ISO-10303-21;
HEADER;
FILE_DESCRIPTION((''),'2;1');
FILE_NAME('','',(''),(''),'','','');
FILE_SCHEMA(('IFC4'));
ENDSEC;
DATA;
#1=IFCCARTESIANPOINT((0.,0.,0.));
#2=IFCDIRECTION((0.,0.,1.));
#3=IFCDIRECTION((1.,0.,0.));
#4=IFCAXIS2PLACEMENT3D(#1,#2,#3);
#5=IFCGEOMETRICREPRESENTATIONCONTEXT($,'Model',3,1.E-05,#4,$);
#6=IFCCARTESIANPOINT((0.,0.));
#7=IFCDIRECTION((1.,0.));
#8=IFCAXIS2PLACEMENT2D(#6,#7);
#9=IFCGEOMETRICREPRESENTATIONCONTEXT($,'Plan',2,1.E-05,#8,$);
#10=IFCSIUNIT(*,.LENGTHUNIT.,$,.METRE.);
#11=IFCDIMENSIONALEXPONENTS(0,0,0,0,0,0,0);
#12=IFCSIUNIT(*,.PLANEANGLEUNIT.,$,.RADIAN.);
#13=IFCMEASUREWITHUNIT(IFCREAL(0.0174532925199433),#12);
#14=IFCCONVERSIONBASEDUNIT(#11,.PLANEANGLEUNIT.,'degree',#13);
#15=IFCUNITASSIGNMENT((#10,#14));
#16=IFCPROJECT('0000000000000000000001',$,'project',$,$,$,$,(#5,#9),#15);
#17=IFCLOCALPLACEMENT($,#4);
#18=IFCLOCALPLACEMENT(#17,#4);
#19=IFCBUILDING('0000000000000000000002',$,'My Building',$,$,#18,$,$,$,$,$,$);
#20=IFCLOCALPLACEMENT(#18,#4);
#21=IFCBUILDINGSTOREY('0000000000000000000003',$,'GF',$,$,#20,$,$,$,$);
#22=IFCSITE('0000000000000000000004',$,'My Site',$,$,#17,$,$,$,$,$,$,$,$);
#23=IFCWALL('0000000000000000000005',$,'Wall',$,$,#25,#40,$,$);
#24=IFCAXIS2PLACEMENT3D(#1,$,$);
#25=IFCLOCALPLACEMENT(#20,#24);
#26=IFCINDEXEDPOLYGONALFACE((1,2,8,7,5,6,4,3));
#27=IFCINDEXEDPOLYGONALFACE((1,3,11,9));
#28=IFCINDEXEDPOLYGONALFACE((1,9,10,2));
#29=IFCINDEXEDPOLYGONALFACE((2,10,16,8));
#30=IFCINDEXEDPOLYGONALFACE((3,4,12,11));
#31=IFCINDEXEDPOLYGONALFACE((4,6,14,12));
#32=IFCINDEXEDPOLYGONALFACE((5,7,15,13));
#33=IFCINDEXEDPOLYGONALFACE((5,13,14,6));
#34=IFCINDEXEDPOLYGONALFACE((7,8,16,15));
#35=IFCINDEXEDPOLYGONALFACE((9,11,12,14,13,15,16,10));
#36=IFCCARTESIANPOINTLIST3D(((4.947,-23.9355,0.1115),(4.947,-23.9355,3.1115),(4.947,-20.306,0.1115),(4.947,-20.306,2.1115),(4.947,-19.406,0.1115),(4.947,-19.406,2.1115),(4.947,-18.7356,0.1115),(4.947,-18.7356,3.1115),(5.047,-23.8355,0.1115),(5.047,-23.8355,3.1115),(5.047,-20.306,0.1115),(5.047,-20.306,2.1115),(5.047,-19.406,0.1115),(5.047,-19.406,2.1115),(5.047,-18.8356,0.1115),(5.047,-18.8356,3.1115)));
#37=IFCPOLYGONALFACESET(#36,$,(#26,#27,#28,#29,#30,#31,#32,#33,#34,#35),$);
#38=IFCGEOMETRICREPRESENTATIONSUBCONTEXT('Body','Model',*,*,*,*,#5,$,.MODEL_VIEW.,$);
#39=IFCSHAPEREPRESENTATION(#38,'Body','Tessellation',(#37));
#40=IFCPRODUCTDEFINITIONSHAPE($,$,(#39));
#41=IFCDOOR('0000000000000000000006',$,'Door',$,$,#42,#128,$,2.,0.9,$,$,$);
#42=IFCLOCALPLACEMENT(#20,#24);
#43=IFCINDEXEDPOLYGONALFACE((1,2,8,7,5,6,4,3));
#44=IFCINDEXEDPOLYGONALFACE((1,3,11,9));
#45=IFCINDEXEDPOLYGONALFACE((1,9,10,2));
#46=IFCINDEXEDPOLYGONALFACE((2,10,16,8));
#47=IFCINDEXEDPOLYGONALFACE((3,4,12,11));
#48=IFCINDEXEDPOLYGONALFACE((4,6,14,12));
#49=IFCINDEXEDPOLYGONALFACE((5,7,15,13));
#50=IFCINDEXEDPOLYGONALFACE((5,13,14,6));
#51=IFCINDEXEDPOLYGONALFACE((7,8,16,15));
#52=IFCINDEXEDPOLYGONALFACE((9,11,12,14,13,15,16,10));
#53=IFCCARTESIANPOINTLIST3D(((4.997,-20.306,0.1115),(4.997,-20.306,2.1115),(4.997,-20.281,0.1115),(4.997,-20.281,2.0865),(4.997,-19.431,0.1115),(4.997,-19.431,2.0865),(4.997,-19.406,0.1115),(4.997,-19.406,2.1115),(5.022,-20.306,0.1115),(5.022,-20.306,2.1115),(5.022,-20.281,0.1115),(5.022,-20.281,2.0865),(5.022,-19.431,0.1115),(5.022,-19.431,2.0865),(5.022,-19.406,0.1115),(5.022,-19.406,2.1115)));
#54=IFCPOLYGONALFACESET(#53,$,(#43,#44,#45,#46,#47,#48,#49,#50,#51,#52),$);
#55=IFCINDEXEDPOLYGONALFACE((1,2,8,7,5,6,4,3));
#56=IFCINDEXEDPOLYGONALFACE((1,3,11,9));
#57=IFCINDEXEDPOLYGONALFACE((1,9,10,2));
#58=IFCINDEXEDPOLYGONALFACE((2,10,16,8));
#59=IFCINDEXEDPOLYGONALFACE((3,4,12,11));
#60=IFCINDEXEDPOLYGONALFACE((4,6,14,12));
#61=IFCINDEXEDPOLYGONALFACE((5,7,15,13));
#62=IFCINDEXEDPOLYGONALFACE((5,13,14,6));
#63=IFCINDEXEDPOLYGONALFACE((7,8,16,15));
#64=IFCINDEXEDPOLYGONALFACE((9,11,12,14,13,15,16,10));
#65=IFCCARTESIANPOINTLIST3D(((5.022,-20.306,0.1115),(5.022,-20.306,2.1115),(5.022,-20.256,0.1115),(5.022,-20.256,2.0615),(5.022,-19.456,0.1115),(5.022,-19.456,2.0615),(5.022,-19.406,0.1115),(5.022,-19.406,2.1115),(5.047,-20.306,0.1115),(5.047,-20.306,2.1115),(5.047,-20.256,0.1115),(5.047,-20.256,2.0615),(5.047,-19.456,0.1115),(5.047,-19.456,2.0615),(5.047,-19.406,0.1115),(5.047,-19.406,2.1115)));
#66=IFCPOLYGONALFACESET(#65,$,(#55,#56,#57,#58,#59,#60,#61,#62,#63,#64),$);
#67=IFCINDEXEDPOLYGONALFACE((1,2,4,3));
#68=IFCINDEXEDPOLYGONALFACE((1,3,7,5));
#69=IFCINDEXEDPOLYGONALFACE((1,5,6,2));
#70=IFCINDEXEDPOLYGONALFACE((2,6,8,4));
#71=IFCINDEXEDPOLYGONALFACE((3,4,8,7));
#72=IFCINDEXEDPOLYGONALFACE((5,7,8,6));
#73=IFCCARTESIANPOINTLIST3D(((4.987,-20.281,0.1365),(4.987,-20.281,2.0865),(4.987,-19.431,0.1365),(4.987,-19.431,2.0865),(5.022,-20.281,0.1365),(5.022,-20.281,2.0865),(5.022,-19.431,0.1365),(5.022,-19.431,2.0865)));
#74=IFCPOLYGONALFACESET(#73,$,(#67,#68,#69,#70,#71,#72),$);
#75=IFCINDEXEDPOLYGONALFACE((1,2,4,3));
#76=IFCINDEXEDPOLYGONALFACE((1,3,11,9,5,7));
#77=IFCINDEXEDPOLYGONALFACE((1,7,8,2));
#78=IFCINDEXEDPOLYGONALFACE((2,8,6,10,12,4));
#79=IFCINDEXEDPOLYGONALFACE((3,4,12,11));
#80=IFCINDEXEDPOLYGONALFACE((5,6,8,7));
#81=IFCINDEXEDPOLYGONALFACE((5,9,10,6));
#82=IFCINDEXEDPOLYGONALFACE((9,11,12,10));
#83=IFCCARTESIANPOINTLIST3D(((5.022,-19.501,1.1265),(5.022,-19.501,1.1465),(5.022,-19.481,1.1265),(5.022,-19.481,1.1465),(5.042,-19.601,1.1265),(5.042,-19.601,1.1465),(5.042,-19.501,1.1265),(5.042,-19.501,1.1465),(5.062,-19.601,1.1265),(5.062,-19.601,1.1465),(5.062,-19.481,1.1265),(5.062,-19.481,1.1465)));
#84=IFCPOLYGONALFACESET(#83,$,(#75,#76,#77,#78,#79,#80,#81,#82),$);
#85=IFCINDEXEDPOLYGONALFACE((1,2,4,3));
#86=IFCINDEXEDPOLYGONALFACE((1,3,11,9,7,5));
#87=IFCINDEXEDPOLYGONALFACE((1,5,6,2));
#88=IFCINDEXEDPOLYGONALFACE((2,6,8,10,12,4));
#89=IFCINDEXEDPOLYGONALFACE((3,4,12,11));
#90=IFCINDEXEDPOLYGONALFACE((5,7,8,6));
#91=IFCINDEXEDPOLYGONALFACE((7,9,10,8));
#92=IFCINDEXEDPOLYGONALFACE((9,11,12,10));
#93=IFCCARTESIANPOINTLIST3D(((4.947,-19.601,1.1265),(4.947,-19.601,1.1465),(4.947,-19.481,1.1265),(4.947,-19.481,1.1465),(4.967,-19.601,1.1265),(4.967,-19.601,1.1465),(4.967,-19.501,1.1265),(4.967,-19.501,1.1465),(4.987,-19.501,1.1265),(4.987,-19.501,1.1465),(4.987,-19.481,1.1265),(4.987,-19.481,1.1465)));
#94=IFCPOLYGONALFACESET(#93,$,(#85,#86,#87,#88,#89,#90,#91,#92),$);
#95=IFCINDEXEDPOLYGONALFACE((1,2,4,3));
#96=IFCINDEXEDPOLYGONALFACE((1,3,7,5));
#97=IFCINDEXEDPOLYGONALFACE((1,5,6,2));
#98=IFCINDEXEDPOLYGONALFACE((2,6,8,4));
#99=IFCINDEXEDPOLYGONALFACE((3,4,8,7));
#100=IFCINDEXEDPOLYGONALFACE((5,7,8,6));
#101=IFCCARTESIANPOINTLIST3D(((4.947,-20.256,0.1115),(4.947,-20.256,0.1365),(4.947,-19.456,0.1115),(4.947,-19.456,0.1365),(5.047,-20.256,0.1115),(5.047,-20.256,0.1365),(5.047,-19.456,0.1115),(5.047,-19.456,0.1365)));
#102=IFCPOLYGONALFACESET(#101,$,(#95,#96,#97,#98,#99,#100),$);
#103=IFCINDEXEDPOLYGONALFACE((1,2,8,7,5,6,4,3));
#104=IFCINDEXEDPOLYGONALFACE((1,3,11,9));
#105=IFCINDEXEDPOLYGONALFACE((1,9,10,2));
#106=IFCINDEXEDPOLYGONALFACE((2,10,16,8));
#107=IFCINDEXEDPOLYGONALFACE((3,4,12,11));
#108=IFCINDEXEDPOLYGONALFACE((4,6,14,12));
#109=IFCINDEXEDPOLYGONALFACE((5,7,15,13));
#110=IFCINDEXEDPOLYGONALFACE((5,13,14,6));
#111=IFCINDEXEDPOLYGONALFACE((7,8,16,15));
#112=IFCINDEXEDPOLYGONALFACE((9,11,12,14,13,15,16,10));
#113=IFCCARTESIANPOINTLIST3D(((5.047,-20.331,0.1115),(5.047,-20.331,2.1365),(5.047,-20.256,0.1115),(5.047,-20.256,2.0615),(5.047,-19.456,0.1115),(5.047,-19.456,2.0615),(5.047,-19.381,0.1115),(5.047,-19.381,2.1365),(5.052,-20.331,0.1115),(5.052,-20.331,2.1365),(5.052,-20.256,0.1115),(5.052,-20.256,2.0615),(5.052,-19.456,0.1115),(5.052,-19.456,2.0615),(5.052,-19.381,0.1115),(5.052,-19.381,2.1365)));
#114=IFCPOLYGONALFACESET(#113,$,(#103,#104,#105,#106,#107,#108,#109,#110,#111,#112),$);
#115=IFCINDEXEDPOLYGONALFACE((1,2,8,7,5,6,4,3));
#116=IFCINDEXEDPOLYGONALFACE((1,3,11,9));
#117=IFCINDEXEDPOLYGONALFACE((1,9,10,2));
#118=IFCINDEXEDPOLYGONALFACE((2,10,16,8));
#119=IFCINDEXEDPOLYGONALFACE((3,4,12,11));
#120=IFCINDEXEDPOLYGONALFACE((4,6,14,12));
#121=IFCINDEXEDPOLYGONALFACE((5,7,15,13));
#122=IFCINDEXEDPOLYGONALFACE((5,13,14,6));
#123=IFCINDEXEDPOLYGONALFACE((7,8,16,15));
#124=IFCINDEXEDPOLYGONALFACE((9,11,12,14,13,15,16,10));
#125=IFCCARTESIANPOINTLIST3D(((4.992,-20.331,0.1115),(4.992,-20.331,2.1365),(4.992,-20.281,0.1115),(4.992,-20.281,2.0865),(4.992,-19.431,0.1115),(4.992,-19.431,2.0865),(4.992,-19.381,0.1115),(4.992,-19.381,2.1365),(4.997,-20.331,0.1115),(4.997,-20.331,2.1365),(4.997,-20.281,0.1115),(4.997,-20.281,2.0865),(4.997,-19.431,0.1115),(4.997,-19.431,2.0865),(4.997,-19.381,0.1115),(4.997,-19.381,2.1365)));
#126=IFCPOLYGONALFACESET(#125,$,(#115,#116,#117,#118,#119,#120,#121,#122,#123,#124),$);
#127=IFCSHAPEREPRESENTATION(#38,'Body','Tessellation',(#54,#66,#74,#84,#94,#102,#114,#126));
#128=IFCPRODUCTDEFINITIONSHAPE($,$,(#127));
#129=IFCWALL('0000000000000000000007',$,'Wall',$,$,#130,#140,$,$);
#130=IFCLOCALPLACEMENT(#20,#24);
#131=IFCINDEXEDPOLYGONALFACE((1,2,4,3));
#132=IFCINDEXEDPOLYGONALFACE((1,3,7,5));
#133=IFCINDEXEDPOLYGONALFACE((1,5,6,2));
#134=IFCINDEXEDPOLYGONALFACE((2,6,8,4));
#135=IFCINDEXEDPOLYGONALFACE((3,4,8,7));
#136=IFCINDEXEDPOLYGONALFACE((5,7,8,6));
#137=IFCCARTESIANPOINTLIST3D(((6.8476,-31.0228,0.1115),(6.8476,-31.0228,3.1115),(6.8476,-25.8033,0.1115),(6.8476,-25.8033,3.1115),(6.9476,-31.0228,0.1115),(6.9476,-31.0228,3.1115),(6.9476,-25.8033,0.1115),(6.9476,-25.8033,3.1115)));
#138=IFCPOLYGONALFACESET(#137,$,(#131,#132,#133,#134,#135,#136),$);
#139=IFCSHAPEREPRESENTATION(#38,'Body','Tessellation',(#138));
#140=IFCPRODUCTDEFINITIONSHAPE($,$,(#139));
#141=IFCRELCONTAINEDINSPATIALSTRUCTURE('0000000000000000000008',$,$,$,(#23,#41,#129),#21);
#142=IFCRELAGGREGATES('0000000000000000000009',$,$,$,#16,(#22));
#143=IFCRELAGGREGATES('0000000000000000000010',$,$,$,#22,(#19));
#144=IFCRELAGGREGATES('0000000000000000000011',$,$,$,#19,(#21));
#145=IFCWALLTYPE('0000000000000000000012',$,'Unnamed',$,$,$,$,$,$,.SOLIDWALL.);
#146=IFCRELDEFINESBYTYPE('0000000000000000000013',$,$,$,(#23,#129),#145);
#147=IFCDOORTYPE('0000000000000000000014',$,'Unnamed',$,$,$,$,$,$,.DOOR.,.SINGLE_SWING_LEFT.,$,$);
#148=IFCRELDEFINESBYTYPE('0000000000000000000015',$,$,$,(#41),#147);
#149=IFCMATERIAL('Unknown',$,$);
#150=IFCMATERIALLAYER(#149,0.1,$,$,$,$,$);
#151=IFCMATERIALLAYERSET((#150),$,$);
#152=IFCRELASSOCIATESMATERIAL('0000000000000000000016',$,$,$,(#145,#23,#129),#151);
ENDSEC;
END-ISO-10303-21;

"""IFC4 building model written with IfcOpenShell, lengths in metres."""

from ifc_helpers import new_model, entity, si_unit, converted_unit, frame, origin_with_axes, origin_2d_with_axis, place, context, subcontext, project, spatial, line, indexed_curve, outline, extrude, shape, source, transform, mapped, material, layer, layer_set, layer_usage, type_object, type_shapes, element, fill, save


model = new_model("IFC4")

# Units and contexts
model_context = context("Model", 3, precision=1e-05, world=origin_with_axes())
plan_context = context("Plan", 2, precision=1e-05, world=origin_2d_with_axis())
body_context_1 = subcontext(model_context, "Body", "Model", "MODEL_VIEW")
body_context_2 = subcontext(plan_context, "Body", "Plan", "PLAN_VIEW")
ifc_project = project(units=[si_unit("LENGTHUNIT", "METRE"), converted_unit("PLANEANGLEUNIT", "degree", entity("IfcReal", 0.0174532925199433), si_unit("PLANEANGLEUNIT", "RADIAN"), dimensions=[0, 0, 0, 0, 0, 0, 0])], contexts=[model_context, plan_context])

# Site, building, storey
site_placement = place(None, origin_with_axes())
site = spatial("IfcSite", under=ifc_project, at=site_placement, Name="My Site")
building_placement = place(site_placement, origin_with_axes())
building = spatial("IfcBuilding", under=site, at=building_placement, Name="My Building")
storey_placement = place(building_placement, origin_with_axes())
storey = spatial("IfcBuildingStorey", under=building, at=storey_placement, Name="GF")

# Shared definitions
ifc_material = material(Name="Unknown")

# Shared definitions
ifc_layer_1 = layer(ifc_material, 0.1)
ifc_layer_set_1 = layer_set([ifc_layer_1])
wall_type = type_object("IfcWallType", Name="Unnamed", PredefinedType="SOLIDWALL", material=ifc_layer_set_1)

# Shared definitions
shared_shape_1 = source(origin_with_axes(), body_context_1, "Body", "SweptSolid", [
    extrude(outline(indexed_curve([(0.0, 0.0), (0.9, 0.0), (0.9, 2.0), (0.0, 2.0)], segments=[line(1, 2, 3, 4, 1)])), frame((0.0, -0.6, 0.0), z_axis=(0.0, -1.0, 0.0), x_axis=(1.0, 0.0, 0.0)), (0.0, 0.0, -1.0), 1.2),
])
door_type = type_object("IfcDoorType", Name="Unnamed", OperationType="SINGLE_SWING_LEFT", PredefinedType="DOOR")
shared_shape_2 = source(origin_with_axes(), body_context_1, "Body", "SweptSolid", [
    extrude(outline(indexed_curve([(0.0, 0.0), (0.0, 2.0), (0.9, 2.0), (0.9, 0.0), (0.875, 0.0), (0.875, 1.975), (0.025, 1.975), (0.025, 0.0)], segments=[line(1, 2, 3, 4, 5, 6, 7, 8, 1)])), frame((0.0, 0.025, 0.0), z_axis=(0.0, -1.0, 0.0), x_axis=(1.0, 0.0, 0.0)), (0.0, 0.0, -1.0), 0.025),
    extrude(outline(indexed_curve([(0.0, 0.0), (0.0, 2.0), (0.9, 2.0), (0.9, 0.0), (0.85, 0.0), (0.85, 1.95), (0.05, 1.95), (0.05, 0.0)], segments=[line(1, 2, 3, 4, 5, 6, 7, 8, 1)])), frame((0.0, 0.0, 0.0), z_axis=(0.0, -1.0, 0.0), x_axis=(1.0, 0.0, 0.0)), (0.0, 0.0, -1.0), 0.025),
    extrude(outline(indexed_curve([(0.0, 0.0), (0.85, 0.0), (0.85, 0.035), (0.0, 0.035)], segments=[line(1, 2, 3, 4, 1)])), frame((0.025, 0.025, 0.025), z_axis=(0.0, 0.0, 1.0), x_axis=(1.0, 0.0, 0.0)), (0.0, 0.0, 1.0), 1.95),
    extrude(outline(indexed_curve([(0.0, 0.0), (0.0, -0.04), (-0.12, -0.04), (-0.12, -0.02), (-0.02, -0.02), (-0.02, 0.0)], segments=[line(1, 2, 3, 4, 5, 6, 1)])), frame((0.825, 0.025, 1.015), z_axis=(0.0, 0.0, 1.0), x_axis=(1.0, 0.0, 0.0)), (0.0, 0.0, 1.0), 0.02),
    extrude(outline(indexed_curve([(0.0, 0.0), (0.0, 0.04), (-0.12, 0.04), (-0.12, 0.02), (-0.02, 0.02), (-0.02, 0.0)], segments=[line(1, 2, 3, 4, 5, 6, 1)])), frame((0.825, 0.06, 1.015), z_axis=(0.0, 0.0, 1.0), x_axis=(1.0, 0.0, 0.0)), (0.0, 0.0, 1.0), 0.02),
    extrude(outline(indexed_curve([(0.0, 0.0), (0.8, 0.0), (0.8, 0.1), (0.0, 0.1)], segments=[line(1, 2, 3, 4, 1)])), frame((0.05, 0.0, 0.0), z_axis=(0.0, 0.0, 1.0), x_axis=(1.0, 0.0, 0.0)), (0.0, 0.0, 1.0), 0.025),
    extrude(outline(indexed_curve([(0.0, 0.0), (0.0, 2.025), (0.95, 2.025), (0.95, 0.0), (0.875, 0.0), (0.875, 1.95), (0.075, 1.95), (0.075, 0.0)], segments=[line(1, 2, 3, 4, 5, 6, 7, 8, 1)])), frame((-0.025, -0.005, 0.0), z_axis=(0.0, -1.0, 0.0), x_axis=(1.0, 0.0, 0.0)), (0.0, 0.0, -1.0), 0.005),
    extrude(outline(indexed_curve([(0.0, 0.0), (0.0, 2.025), (0.95, 2.025), (0.95, 0.0), (0.9, 0.0), (0.9, 1.975), (0.05, 1.975), (0.05, 0.0)], segments=[line(1, 2, 3, 4, 5, 6, 7, 8, 1)])), frame((-0.025, 0.05, 0.0), z_axis=(0.0, -1.0, 0.0), x_axis=(1.0, 0.0, 0.0)), (0.0, 0.0, -1.0), 0.005),
])
shared_shape_3 = source(origin_with_axes(), body_context_2, "Body", "Curve2D", [
    entity("IfcIndexedPolyCurve", entity("IfcCartesianPointList2D", [[0.0, 0.0], [0.0, 0.05], [0.025, 0.05], [0.025, 0.025], [0.05, 0.025], [0.05, 0.0]]), [entity("IfcLineIndex", [1, 2, 3, 4, 5, 6, 1])]),
    entity("IfcIndexedPolyCurve", entity("IfcCartesianPointList2D", [[0.9, 0.0], [0.9, 0.05], [0.875, 0.05], [0.875, 0.025], [0.85, 0.025], [0.85, 0.0]]), [entity("IfcLineIndex", [1, 2, 3, 4, 5, 6, 1])]),
    entity("IfcTrimmedCurve", entity("IfcEllipse", entity("IfcAxis2Placement2D", entity("IfcCartesianPoint", [0.06, 0.05]), entity("IfcDirection", [1.0, 0.0])), 0.815, 0.85), [entity("IfcCartesianPoint", [0.875, 0.05])], [entity("IfcCartesianPoint", [0.06, 0.9])], True, "CARTESIAN"),
    entity("IfcIndexedPolyCurve", entity("IfcCartesianPointList2D", [[0.025, 0.05], [0.06, 0.05], [0.06, 0.9], [0.025, 0.9]]), [entity("IfcLineIndex", [1, 2, 3, 4, 1])]),
])
type_shapes(door_type, [shared_shape_2, shared_shape_3])

# Wall, opening, door
ifc_layer_usage_1 = layer_usage(ifc_layer_set_1, "AXIS2", "POSITIVE", 0.0)
wall_1_placement = place(storey_placement, frame((5.047, -23.8355, 0.1115), z_axis=(0.0, 0.0, 1.0), x_axis=(0.0, 1.0, 0.0)))
wall_1 = element("IfcWall", 1, at=wall_1_placement, inside=storey, type_object=wall_type, material=ifc_layer_usage_1, Name="Wall", context=body_context_1, shape_type="SweptSolid", body=[
    extrude(outline(indexed_curve([(0.0, 0.0), (-0.1, 0.1), (5.1, 0.1), (5.0, 0.0)], segments=[line(1, 2, 3, 4, 1)])), origin_with_axes(), (0.0, 0.0, 1.0), 3.0),
])
opening_1_placement = place(wall_1_placement, frame((3.5295, 0.0, 0.0), z_axis=(0.0, 0.0, 1.0), x_axis=(1.0, 0.0, 0.0)))
opening_1 = element("IfcOpeningElement", 2, at=opening_1_placement, cuts=wall_1, PredefinedType="OPENING", context=body_context_1, shape_type="MappedRepresentation", body=[
    mapped(shared_shape_1, transform((0.0, 0.0, 0.0), x_axis=(1.0, 0.0, 0.0), y_axis=(0.0, 1.0, 0.0), z_axis=(0.0, 0.0, 1.0), scale=1.0)),
])
door_1_placement = place(opening_1_placement, frame((0.0, 0.0, 0.0), z_axis=(0.0, 0.0, 1.0), x_axis=(1.0, 0.0, 0.0)))
door_1 = element("IfcDoor", 3, at=door_1_placement, inside=storey, type_object=door_type, Name="Door", OverallHeight=2.0, OverallWidth=0.9, shapes=[
    shape(body_context_1, "Body", "MappedRepresentation", [mapped(shared_shape_2, transform((0.0, 0.0, 0.0), x_axis=(1.0, 0.0, 0.0), y_axis=(0.0, 1.0, 0.0), z_axis=(0.0, 0.0, 1.0), scale=1.0))]),
    shape(body_context_2, "Body", "MappedRepresentation", [mapped(shared_shape_3, transform((0.0, 0.0, 0.0), x_axis=(1.0, 0.0, 0.0), y_axis=(0.0, 1.0, 0.0), z_axis=(0.0, 0.0, 1.0), scale=1.0))]),
])
fill(opening_1, door_1)

# Wall
ifc_layer_usage_2 = layer_usage(ifc_layer_set_1, "AXIS2", "POSITIVE", 0.0)
wall_2_placement = place(storey_placement, frame((6.8476, -25.8033, 0.1115), z_axis=(0.0, 0.0, 1.0), x_axis=(0.0, -1.0, 0.0)))
element("IfcWall", 4, at=wall_2_placement, inside=storey, type_object=wall_type, material=ifc_layer_usage_2, Name="Wall", context=body_context_1, shape_type="SweptSolid", body=[
    extrude(outline(indexed_curve([(0.0, 0.0), (0.0, 0.1), (5.2195, 0.1), (5.2195, 0.0)], segments=[line(1, 2, 3, 4, 1)])), origin_with_axes(), (0.0, 0.0, 1.0), 3.0),
])

save(model, "model.ifc")
